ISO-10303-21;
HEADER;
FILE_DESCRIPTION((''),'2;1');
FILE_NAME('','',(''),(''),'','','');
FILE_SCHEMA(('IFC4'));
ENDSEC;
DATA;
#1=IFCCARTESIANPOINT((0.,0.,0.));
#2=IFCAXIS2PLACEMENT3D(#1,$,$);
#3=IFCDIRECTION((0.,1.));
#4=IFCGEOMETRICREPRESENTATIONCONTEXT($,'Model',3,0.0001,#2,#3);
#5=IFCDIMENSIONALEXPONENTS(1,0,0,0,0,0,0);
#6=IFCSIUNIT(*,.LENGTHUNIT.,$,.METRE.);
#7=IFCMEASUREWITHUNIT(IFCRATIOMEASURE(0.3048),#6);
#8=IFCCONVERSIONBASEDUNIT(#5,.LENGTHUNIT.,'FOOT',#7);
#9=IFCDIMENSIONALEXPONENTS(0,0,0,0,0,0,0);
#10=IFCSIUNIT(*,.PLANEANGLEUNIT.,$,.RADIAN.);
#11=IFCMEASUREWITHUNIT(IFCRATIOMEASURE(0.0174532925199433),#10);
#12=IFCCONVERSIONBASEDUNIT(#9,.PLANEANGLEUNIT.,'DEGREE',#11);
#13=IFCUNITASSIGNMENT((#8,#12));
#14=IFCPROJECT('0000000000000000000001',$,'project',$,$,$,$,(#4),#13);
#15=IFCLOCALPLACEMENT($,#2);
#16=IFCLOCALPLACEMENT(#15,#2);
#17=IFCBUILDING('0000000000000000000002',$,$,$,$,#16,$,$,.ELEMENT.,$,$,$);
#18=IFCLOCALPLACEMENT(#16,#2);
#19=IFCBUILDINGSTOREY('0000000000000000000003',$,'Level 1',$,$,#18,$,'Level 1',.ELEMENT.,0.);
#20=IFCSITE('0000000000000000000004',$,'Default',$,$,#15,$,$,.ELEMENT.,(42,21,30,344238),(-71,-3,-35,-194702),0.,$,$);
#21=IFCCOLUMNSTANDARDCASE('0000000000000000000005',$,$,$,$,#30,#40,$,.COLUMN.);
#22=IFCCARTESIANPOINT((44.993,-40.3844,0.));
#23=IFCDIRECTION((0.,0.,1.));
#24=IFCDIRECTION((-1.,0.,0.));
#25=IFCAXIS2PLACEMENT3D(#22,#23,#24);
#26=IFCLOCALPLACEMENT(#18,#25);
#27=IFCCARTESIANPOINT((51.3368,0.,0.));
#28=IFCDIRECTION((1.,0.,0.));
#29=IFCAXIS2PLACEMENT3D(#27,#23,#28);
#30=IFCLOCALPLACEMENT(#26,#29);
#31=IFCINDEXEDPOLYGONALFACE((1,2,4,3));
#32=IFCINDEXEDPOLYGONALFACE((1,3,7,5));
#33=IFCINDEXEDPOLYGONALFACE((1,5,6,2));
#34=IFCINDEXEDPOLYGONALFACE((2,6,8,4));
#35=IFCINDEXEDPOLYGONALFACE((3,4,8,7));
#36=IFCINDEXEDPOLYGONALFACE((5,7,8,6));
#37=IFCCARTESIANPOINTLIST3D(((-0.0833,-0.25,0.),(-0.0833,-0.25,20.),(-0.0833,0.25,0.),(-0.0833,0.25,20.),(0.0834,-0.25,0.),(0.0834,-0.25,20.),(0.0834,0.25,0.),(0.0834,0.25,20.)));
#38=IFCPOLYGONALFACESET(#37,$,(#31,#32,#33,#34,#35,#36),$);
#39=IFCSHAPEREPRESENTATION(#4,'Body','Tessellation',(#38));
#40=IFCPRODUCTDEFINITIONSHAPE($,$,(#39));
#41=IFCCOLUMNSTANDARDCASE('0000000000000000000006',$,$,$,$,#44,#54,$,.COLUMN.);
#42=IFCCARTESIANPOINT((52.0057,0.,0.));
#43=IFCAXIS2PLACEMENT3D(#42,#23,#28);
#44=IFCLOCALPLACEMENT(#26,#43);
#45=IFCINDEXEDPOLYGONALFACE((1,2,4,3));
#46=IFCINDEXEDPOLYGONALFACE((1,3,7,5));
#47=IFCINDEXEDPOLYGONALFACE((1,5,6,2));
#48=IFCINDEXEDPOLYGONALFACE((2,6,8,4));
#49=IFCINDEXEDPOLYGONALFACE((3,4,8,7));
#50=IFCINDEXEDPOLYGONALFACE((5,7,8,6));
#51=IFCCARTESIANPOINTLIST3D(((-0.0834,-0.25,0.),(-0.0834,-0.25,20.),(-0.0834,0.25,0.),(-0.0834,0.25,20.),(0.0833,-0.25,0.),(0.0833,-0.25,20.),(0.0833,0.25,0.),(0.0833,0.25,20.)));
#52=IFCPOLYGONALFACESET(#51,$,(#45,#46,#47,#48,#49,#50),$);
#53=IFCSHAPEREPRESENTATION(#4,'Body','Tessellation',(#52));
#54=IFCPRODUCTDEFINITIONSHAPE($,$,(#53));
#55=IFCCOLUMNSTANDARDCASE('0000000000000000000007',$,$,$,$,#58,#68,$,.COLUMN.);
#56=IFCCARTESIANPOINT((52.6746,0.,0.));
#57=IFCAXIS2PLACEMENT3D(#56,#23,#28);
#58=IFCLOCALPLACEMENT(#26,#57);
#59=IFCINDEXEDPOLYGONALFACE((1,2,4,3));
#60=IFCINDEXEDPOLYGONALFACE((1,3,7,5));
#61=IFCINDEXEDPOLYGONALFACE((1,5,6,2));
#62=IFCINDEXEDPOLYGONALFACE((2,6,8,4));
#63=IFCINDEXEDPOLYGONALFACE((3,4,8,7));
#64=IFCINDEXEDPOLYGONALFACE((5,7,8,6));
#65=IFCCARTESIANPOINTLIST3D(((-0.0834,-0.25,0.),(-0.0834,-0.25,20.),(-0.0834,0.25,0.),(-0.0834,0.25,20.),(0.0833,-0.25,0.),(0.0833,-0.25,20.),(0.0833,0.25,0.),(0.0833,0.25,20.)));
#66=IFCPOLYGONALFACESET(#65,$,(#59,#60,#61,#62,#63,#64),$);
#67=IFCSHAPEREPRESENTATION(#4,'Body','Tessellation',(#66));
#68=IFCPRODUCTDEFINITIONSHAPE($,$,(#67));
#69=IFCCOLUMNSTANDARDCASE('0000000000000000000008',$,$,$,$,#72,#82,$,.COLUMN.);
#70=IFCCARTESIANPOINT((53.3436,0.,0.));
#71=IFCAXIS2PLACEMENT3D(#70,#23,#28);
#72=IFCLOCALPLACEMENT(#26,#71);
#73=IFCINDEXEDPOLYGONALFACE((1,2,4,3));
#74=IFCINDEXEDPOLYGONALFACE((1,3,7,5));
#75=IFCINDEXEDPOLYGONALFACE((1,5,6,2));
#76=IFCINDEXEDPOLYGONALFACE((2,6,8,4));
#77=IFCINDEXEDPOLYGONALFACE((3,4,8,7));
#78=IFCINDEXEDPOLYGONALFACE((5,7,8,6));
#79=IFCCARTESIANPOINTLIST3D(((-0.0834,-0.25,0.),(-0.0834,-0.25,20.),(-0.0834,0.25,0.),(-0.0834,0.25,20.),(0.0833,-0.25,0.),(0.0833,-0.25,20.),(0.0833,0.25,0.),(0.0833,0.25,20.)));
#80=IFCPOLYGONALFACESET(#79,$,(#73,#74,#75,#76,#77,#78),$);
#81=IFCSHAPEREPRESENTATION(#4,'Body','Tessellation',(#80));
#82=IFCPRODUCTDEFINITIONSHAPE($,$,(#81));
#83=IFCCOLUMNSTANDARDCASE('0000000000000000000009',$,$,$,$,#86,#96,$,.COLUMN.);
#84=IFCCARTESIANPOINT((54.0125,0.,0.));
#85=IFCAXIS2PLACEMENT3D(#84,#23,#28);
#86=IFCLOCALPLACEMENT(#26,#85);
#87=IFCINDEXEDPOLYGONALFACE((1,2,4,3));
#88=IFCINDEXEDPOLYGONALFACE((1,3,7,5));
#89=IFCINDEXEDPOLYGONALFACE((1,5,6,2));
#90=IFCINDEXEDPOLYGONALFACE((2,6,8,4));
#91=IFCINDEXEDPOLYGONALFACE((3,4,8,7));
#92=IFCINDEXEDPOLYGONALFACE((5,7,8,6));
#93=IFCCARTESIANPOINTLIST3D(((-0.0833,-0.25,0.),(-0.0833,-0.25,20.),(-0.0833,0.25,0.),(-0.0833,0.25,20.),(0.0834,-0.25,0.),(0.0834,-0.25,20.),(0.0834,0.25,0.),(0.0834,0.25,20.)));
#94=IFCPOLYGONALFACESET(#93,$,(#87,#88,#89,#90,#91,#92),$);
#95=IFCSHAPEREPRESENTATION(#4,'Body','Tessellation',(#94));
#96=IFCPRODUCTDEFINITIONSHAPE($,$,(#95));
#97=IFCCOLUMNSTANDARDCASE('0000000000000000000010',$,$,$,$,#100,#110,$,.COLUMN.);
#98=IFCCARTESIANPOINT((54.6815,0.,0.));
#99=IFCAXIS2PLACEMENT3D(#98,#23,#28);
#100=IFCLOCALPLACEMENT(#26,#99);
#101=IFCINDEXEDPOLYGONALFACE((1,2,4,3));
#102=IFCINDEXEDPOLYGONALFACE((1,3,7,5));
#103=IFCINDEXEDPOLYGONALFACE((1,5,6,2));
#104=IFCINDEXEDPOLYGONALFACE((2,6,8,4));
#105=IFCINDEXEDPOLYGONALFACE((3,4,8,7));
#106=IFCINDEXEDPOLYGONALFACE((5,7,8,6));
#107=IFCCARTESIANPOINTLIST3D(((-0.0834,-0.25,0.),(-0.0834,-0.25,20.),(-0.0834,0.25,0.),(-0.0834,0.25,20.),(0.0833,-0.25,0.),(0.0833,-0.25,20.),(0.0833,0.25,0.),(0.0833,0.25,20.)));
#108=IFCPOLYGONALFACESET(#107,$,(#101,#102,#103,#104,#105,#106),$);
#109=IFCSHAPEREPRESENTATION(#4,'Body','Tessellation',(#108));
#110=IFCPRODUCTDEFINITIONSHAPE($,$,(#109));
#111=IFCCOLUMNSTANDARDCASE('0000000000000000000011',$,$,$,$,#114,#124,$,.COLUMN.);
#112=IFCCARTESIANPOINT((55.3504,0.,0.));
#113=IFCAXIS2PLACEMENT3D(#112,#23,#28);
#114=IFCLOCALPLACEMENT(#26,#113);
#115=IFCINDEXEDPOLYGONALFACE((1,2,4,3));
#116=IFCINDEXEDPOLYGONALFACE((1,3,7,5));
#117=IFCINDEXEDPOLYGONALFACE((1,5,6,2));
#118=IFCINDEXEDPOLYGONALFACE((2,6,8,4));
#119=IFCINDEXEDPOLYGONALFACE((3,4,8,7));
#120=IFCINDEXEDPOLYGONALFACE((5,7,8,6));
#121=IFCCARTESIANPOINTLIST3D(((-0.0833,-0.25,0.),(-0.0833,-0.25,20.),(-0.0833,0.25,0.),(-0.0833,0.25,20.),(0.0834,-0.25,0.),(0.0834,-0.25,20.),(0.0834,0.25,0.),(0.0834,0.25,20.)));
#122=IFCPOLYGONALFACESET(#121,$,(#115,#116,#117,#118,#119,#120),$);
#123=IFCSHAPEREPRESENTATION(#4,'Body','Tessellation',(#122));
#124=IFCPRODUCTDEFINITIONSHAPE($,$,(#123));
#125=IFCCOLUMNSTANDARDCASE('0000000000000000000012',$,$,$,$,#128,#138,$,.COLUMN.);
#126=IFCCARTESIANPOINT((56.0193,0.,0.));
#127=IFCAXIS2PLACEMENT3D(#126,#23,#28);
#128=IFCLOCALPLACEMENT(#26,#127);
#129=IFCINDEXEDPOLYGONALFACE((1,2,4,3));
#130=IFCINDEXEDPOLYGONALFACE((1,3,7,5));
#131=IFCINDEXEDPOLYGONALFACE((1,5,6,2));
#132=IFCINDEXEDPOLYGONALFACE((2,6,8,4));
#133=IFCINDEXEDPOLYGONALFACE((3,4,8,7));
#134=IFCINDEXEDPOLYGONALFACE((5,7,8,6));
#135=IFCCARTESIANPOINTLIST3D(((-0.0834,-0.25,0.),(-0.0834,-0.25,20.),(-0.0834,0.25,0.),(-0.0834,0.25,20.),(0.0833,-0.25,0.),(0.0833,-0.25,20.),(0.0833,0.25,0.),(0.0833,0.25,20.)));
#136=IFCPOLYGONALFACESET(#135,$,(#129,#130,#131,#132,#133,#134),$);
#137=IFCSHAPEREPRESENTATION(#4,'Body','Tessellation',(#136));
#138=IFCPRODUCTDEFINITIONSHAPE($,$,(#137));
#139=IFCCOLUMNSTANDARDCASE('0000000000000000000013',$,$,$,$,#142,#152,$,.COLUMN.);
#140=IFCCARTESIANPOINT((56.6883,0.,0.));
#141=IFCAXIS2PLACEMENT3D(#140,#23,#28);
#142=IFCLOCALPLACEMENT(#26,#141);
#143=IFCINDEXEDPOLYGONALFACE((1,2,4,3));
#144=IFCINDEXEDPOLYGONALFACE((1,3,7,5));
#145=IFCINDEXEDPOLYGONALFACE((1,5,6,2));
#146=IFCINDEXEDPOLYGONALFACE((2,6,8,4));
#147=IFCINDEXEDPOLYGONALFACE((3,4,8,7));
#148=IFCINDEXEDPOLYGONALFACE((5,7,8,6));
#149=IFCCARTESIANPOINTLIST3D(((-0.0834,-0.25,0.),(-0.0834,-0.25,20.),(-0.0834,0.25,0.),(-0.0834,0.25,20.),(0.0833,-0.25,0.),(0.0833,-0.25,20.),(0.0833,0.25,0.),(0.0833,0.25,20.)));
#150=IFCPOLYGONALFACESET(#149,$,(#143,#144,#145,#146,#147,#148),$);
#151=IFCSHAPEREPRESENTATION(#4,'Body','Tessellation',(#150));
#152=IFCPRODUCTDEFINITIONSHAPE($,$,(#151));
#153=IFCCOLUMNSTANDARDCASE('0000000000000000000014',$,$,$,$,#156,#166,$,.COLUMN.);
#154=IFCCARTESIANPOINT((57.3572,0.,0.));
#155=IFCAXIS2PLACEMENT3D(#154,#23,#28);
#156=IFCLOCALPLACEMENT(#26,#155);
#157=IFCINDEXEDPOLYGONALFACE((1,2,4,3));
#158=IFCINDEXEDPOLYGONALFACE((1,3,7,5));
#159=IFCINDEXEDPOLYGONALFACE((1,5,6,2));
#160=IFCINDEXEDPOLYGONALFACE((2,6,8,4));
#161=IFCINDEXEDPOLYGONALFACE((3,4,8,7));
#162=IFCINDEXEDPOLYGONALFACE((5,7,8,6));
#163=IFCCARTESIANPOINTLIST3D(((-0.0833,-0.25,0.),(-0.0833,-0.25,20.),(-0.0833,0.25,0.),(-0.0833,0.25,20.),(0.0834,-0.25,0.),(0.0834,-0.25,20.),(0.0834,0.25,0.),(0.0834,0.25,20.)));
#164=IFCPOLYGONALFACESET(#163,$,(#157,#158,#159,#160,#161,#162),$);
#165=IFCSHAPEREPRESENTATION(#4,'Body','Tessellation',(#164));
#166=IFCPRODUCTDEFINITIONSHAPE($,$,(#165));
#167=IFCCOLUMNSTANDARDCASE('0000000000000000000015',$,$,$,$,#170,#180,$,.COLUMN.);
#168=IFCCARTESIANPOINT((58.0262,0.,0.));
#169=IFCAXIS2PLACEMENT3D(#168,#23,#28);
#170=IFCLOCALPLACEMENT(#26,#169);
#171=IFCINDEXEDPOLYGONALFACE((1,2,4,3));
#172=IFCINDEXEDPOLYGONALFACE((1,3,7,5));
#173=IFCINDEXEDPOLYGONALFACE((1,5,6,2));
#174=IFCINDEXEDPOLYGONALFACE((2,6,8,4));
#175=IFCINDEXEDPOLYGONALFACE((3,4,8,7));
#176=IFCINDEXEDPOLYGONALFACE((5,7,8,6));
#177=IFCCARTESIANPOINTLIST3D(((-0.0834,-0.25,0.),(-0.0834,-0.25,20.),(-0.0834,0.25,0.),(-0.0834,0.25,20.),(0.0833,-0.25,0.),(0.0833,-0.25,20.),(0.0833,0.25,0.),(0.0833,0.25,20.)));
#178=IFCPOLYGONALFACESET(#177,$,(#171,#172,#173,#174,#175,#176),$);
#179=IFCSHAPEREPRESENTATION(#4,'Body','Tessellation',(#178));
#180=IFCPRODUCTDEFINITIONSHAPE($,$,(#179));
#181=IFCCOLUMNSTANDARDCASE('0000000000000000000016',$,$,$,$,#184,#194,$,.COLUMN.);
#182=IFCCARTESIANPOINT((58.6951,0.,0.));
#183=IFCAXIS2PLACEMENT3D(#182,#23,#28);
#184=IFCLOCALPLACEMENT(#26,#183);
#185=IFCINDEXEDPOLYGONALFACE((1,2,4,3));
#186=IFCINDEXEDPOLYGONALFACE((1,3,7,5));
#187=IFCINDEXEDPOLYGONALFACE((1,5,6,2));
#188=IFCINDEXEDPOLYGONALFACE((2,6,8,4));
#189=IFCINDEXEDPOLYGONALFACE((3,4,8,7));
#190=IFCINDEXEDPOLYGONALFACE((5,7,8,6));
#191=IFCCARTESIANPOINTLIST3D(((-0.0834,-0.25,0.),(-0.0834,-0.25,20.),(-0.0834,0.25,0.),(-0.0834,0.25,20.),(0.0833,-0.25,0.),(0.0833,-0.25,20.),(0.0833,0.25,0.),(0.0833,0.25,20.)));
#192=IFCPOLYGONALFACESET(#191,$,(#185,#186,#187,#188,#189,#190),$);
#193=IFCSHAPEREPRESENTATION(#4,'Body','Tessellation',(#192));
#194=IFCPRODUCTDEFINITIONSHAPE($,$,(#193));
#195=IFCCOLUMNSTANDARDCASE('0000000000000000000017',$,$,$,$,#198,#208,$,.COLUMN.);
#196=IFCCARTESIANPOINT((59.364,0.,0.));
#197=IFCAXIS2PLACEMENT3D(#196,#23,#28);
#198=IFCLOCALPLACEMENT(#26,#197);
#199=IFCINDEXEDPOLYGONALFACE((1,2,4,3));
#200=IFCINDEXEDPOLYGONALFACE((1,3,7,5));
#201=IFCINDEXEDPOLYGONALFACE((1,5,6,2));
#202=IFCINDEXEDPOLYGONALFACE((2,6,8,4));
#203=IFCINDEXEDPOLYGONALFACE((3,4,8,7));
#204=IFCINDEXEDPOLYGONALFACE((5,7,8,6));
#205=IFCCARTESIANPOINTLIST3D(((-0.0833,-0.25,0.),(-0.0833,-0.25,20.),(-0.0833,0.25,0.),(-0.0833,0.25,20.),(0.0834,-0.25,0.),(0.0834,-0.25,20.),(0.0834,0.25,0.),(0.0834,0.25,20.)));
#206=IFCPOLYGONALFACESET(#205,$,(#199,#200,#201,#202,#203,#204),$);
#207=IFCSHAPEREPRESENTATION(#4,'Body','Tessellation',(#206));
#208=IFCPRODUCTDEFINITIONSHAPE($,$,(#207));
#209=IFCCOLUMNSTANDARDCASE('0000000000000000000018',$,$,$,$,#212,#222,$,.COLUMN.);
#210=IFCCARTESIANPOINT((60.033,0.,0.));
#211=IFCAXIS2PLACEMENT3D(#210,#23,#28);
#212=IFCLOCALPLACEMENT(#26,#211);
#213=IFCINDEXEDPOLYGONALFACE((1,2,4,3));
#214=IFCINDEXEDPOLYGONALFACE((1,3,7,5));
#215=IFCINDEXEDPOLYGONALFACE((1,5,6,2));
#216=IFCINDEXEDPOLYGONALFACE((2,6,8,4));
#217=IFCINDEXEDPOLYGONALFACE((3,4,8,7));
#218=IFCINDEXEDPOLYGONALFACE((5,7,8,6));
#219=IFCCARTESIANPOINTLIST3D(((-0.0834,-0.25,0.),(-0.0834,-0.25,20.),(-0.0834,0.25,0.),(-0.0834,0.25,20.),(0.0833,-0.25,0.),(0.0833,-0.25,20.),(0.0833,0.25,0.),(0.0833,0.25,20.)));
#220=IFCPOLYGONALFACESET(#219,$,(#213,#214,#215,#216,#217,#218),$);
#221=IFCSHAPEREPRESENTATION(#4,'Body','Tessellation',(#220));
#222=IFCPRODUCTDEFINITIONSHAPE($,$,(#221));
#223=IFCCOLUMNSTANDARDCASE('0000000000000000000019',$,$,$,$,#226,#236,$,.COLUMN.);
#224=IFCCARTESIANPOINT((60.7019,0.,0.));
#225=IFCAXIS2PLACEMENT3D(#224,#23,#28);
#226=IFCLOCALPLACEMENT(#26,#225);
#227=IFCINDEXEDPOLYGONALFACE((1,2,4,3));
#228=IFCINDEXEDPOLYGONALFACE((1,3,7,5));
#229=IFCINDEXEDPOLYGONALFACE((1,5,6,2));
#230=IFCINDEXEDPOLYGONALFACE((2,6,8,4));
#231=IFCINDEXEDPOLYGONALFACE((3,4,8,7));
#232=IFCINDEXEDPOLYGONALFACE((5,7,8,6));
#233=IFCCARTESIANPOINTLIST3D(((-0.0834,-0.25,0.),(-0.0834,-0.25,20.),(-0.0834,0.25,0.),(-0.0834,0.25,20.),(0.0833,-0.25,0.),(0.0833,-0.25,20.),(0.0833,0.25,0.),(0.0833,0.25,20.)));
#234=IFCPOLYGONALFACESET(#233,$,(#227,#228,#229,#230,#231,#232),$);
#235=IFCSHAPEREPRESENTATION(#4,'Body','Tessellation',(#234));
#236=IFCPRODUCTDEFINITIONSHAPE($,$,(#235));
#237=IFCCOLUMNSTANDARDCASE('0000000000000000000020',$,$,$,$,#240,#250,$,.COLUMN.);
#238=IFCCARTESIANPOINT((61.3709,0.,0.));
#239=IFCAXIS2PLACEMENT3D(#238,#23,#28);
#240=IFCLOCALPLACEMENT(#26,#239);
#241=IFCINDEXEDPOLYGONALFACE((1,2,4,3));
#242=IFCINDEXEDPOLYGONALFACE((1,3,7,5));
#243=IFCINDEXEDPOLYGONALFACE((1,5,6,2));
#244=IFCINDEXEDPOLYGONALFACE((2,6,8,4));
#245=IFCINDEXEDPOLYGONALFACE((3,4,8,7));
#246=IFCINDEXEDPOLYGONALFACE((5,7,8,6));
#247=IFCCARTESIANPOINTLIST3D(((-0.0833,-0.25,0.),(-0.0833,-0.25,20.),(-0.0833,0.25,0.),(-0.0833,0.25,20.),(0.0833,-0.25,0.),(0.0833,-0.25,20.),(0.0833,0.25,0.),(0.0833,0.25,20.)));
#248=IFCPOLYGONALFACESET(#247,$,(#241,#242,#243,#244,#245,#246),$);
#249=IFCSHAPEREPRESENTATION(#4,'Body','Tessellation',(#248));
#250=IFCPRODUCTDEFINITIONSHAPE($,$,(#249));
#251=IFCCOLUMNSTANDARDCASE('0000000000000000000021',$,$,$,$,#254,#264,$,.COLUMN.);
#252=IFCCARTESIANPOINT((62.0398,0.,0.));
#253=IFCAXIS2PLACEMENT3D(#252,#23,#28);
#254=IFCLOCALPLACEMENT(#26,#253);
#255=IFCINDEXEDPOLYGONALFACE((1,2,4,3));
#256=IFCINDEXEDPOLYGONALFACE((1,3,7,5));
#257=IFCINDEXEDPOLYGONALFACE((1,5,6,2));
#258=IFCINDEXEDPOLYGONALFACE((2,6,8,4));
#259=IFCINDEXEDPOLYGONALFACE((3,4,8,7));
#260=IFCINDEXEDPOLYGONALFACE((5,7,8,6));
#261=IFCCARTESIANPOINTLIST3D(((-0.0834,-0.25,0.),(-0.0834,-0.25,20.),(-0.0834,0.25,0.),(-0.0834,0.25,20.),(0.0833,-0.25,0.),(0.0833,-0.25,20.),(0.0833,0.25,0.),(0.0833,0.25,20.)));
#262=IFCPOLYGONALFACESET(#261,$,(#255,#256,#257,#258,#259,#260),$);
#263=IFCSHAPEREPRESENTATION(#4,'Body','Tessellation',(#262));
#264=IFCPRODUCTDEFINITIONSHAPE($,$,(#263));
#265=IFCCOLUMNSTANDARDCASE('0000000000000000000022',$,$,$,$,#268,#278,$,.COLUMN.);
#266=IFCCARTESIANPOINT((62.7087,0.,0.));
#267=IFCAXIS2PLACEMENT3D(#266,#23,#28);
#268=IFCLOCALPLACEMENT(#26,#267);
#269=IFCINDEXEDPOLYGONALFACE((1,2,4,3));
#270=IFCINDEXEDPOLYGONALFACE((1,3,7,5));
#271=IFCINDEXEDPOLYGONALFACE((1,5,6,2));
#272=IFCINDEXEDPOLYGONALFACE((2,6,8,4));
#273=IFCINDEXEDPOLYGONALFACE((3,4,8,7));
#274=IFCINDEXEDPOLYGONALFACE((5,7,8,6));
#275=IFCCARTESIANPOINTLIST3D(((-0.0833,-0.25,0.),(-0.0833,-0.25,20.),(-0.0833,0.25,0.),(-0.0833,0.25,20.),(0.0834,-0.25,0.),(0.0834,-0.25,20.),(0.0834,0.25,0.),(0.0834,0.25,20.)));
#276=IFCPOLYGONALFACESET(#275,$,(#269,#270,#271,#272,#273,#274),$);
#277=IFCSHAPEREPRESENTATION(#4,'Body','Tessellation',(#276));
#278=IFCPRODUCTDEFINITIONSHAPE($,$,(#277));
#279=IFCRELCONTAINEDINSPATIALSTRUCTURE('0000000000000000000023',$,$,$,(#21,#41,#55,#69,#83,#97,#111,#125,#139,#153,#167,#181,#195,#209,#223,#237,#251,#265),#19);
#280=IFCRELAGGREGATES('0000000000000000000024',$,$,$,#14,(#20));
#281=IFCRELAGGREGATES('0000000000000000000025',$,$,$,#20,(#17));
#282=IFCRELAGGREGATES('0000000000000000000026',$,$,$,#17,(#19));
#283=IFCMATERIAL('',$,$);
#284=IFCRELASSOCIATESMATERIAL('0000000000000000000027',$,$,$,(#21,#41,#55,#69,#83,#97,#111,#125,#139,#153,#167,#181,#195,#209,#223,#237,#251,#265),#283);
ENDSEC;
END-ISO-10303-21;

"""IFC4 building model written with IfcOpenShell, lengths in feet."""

from ifc_helpers import new_model, entity, si_unit, converted_unit, direction, frame, origin, place, context, project, spatial, rectangle, extrude, material, element, save


model = new_model("IFC4")

# Units and contexts
model_context = context("Model", 3, precision=0.0001, world=origin(), true_north=direction((0.0, 1.0)))
ifc_project = project(units=[converted_unit("LENGTHUNIT", "FOOT", entity("IfcRatioMeasure", 0.3048), si_unit("LENGTHUNIT", "METRE"), dimensions=[1, 0, 0, 0, 0, 0, 0]), converted_unit("PLANEANGLEUNIT", "DEGREE", entity("IfcRatioMeasure", 0.0174532925199433), si_unit("PLANEANGLEUNIT", "RADIAN"), dimensions=[0, 0, 0, 0, 0, 0, 0])], contexts=[model_context])

# Site, building, storey
site_placement = place(None, origin())
site = spatial("IfcSite", under=ifc_project, at=site_placement, Name="Default", CompositionType="ELEMENT", RefLatitude=(42, 21, 30, 344238), RefLongitude=(-71, -3, -35, -194702), RefElevation=0.0)
building_placement = place(site_placement, origin())
building = spatial("IfcBuilding", under=site, at=building_placement, CompositionType="ELEMENT")
storey_placement = place(building_placement, origin())
storey = spatial("IfcBuildingStorey", under=building, at=storey_placement, Name="Level 1", LongName="Level 1", CompositionType="ELEMENT", Elevation=0.0)

# Columns
ifc_material_1 = material(Name="")
placement = place(storey_placement, frame((44.993, -40.3844, 0.0), z_axis=(0.0, 0.0, 1.0), x_axis=(-1.0, 0.0, 0.0)))
for number, where, z_axis, x_axis in (
    (1, (51.3368, 0.0, 0.0), (0.0, 0.0, 1.0), (1.0, 0.0, 0.0)),
    (2, (52.0057, 0.0, 0.0), (0.0, 0.0, 1.0), (1.0, 0.0, 0.0)),
    (3, (52.6746, 0.0, 0.0), (0.0, 0.0, 1.0), (1.0, 0.0, 0.0)),
    (4, (53.3436, 0.0, 0.0), (0.0, 0.0, 1.0), (1.0, 0.0, 0.0)),
    (5, (54.0125, 0.0, 0.0), (0.0, 0.0, 1.0), (1.0, 0.0, 0.0)),
    (6, (54.6815, 0.0, 0.0), (0.0, 0.0, 1.0), (1.0, 0.0, 0.0)),
    (7, (55.3504, 0.0, 0.0), (0.0, 0.0, 1.0), (1.0, 0.0, 0.0)),
    (8, (56.0193, 0.0, 0.0), (0.0, 0.0, 1.0), (1.0, 0.0, 0.0)),
    (9, (56.6883, 0.0, 0.0), (0.0, 0.0, 1.0), (1.0, 0.0, 0.0)),
    (10, (57.3572, 0.0, 0.0), (0.0, 0.0, 1.0), (1.0, 0.0, 0.0)),
    (11, (58.0262, 0.0, 0.0), (0.0, 0.0, 1.0), (1.0, 0.0, 0.0)),
    (12, (58.6951, 0.0, 0.0), (0.0, 0.0, 1.0), (1.0, 0.0, 0.0)),
    (13, (59.364, 0.0, 0.0), (0.0, 0.0, 1.0), (1.0, 0.0, 0.0)),
    (14, (60.033, 0.0, 0.0), (0.0, 0.0, 1.0), (1.0, 0.0, 0.0)),
    (15, (60.7019, 0.0, 0.0), (0.0, 0.0, 1.0), (1.0, 0.0, 0.0)),
    (16, (61.3709, 0.0, 0.0), (0.0, 0.0, 1.0), (1.0, 0.0, 0.0)),
    (17, (62.0398, 0.0, 0.0), (0.0, 0.0, 1.0), (1.0, 0.0, 0.0)),
    (18, (62.7087, 0.0, 0.0), (0.0, 0.0, 1.0), (1.0, 0.0, 0.0)),
):
    element("IfcColumnStandardCase", number, at=place(placement, frame(where, z_axis=z_axis, x_axis=x_axis)), inside=storey, material=ifc_material_1, PredefinedType="COLUMN", context=model_context, shape_type="SweptSolid", body=[
        extrude(rectangle(XDim=0.1667, YDim=0.5), origin(), (0.0, 0.0, 1.0), 20.0),
    ])

save(model, "model.ifc")
